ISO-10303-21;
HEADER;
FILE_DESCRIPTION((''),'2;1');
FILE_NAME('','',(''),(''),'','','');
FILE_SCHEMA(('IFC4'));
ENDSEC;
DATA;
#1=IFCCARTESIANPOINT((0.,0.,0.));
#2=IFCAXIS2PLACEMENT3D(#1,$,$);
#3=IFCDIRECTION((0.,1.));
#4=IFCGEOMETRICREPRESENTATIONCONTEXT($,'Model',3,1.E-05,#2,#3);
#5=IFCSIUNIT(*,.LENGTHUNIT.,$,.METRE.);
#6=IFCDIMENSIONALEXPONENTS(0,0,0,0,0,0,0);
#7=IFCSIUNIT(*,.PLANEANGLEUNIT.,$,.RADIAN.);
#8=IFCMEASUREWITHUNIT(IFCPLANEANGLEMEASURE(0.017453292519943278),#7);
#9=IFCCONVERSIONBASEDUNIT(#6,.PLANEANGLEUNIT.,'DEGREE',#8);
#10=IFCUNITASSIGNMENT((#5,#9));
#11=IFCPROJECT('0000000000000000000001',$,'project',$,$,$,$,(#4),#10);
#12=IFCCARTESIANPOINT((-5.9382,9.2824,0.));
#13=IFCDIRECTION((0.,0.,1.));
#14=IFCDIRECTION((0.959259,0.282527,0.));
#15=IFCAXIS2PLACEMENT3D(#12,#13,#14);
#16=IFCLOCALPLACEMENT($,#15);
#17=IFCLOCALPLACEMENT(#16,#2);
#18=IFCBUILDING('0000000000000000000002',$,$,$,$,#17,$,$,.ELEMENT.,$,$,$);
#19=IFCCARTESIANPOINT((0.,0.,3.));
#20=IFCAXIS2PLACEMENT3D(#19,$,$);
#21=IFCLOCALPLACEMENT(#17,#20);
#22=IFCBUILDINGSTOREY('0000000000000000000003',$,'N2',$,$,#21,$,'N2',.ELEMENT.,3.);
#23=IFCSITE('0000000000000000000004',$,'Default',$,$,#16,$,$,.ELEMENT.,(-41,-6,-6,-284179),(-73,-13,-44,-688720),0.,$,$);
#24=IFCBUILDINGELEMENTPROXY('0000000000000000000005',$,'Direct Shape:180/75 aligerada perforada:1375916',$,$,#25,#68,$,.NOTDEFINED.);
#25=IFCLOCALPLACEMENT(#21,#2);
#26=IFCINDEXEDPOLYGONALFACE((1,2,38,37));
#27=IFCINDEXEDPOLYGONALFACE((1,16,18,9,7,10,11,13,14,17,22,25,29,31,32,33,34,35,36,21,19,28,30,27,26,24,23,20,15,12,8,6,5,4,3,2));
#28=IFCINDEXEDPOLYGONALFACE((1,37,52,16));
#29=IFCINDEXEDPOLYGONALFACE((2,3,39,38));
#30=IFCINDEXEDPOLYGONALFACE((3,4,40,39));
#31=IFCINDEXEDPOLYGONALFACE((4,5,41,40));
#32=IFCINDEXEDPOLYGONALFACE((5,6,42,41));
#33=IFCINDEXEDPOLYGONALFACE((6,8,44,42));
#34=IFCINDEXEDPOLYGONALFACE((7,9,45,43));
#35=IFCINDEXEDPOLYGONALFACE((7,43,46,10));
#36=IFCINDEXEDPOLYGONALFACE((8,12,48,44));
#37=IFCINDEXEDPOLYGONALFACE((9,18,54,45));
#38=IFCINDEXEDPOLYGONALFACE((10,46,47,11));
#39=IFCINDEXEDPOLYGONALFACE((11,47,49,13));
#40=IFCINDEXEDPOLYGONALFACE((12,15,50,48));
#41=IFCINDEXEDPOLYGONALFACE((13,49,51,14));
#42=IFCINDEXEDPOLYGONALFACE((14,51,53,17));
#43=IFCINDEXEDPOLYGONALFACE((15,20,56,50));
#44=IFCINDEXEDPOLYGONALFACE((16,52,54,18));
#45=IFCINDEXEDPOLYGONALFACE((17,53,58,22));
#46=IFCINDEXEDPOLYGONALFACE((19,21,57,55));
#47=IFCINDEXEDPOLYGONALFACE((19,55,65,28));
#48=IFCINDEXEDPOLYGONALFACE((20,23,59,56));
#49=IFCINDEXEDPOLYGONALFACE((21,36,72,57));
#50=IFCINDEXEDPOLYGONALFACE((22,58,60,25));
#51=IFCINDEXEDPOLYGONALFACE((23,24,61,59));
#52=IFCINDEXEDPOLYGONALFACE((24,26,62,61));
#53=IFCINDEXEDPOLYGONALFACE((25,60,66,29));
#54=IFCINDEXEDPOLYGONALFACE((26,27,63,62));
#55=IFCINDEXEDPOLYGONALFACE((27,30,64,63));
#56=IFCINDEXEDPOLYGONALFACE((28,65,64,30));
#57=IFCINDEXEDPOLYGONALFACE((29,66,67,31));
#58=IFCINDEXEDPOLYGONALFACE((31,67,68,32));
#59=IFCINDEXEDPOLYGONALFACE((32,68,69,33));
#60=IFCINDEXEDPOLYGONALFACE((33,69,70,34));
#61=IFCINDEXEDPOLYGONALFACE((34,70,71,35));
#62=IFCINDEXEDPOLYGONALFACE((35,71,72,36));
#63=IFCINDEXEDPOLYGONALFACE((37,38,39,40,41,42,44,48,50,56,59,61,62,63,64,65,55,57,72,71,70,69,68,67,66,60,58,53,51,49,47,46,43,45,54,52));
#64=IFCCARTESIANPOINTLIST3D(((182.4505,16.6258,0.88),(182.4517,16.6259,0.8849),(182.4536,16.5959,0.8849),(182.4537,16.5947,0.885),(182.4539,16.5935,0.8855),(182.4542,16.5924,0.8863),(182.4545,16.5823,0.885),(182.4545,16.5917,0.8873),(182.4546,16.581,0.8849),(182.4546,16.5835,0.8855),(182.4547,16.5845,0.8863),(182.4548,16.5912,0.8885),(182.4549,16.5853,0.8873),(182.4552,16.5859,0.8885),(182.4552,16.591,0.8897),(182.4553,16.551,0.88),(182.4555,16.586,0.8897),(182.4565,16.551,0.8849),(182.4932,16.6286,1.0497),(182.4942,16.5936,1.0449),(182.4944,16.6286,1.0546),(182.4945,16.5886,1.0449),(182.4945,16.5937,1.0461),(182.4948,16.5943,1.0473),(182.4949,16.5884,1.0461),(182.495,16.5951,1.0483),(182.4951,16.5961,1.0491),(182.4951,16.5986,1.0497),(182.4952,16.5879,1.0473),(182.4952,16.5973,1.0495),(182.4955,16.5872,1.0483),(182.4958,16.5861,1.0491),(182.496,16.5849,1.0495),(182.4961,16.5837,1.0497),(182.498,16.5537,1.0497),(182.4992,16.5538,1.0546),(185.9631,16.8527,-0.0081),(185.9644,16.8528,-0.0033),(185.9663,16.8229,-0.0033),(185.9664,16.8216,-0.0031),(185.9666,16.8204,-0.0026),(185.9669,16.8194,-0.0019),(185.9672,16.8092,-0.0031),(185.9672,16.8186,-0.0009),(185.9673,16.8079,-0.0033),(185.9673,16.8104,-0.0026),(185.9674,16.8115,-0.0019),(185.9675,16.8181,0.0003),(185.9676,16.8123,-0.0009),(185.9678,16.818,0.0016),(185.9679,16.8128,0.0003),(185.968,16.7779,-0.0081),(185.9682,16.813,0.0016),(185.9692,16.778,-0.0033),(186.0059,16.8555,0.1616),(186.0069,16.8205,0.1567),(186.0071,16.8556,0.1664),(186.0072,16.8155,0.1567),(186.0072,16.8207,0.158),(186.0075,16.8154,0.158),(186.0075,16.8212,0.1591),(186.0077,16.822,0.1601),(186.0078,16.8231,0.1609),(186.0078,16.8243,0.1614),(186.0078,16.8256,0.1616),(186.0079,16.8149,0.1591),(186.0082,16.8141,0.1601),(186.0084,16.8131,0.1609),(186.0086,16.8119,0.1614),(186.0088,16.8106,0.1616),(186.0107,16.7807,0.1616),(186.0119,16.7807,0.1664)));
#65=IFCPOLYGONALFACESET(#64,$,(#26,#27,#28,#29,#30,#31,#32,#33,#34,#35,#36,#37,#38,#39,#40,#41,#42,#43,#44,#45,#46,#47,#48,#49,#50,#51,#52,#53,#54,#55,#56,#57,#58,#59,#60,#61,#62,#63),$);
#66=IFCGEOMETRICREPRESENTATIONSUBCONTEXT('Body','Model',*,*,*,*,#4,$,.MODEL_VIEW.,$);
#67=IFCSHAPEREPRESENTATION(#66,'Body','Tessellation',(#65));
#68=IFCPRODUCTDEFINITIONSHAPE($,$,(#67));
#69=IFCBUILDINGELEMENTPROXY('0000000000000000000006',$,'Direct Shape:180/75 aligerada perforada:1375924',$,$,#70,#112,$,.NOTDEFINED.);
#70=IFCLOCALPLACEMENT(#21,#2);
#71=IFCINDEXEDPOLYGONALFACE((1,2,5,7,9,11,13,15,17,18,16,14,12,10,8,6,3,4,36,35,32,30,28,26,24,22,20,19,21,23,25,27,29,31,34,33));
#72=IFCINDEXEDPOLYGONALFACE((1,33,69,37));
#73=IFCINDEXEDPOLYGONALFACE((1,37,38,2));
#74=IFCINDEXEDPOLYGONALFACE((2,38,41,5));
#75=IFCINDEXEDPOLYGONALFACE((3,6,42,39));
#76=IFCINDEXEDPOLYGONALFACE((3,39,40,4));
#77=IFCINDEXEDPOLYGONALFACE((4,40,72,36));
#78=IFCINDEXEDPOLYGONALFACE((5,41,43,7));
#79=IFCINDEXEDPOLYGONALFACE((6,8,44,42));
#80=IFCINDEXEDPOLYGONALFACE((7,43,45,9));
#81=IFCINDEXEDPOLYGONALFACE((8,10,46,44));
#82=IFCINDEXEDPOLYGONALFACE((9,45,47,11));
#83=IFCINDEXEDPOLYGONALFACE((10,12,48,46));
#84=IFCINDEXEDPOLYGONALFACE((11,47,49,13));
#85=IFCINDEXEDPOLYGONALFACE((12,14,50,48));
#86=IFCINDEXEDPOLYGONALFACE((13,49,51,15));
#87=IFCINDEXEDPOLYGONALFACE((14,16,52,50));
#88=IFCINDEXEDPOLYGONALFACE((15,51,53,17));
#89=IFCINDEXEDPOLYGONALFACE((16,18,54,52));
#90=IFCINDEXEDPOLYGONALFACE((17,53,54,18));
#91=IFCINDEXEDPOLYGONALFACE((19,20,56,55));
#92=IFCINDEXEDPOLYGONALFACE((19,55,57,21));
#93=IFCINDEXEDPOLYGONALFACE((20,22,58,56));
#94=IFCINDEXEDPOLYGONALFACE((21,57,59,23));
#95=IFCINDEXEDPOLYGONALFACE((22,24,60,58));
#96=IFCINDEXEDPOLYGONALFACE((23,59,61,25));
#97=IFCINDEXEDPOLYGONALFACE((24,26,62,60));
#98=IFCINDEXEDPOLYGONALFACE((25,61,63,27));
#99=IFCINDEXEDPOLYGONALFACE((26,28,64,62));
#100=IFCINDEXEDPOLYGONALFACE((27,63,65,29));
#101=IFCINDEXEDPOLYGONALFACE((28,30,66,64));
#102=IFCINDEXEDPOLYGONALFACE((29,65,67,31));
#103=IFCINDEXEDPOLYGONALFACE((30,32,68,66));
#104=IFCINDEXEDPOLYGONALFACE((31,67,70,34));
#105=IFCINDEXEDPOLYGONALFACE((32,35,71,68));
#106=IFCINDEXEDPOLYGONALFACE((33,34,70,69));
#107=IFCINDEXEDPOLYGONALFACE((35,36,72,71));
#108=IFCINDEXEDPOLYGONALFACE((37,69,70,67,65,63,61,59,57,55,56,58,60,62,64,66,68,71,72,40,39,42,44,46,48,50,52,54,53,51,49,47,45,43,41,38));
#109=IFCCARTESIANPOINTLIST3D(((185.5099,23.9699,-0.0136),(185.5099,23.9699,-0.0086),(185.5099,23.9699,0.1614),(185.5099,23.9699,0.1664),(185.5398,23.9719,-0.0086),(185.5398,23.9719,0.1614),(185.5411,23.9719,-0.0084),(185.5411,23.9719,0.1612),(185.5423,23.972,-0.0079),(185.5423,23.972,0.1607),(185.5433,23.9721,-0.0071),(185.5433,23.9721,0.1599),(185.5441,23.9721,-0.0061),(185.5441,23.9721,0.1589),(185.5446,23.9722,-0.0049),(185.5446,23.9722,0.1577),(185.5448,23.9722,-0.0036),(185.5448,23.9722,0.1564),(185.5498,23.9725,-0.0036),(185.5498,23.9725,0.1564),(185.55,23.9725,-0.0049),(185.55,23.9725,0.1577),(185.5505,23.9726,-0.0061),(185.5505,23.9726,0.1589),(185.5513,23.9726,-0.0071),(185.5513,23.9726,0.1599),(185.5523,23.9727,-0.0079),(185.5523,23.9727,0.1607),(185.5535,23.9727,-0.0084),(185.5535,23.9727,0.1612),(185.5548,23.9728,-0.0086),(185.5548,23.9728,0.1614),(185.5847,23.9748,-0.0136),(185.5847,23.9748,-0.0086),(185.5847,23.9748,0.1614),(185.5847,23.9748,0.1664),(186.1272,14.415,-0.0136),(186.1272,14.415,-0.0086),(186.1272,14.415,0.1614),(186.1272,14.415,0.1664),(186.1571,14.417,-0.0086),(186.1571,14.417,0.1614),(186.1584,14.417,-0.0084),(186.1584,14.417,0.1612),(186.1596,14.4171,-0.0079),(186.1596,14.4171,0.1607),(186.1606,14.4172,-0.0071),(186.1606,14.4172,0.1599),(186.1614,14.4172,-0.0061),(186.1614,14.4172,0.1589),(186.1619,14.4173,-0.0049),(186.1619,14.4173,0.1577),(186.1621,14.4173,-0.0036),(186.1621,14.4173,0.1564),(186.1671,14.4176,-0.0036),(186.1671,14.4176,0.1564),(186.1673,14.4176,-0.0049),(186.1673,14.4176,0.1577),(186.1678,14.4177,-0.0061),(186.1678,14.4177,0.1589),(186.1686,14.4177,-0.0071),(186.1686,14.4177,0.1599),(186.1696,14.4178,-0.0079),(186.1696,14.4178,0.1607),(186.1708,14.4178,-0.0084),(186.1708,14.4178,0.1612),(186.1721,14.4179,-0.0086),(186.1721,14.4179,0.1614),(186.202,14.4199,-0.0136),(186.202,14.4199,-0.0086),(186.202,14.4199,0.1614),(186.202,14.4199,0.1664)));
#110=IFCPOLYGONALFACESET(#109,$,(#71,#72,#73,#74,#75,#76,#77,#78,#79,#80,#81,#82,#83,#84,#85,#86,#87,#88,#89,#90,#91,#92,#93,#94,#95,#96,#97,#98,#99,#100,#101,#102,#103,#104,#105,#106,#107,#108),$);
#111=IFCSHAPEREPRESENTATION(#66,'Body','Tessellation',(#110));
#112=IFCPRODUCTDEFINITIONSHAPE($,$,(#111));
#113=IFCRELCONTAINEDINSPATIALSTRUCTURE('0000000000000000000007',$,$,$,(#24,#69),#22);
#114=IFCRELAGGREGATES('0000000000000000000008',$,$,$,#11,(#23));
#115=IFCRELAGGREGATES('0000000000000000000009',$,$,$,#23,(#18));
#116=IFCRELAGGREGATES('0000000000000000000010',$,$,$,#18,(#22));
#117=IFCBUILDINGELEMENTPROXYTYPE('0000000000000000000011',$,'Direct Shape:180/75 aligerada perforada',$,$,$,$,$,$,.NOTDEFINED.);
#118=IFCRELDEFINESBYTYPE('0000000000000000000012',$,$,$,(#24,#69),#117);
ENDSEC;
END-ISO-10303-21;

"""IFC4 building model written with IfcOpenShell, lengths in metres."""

from ifc_helpers import new_model, entity, si_unit, converted_unit, direction, frame, frame_2d, origin, place, context, subcontext, project, spatial, polyline, circle_curve, parameter, trimmed, segment, composite_curve, outline, extrude, type_object, element, save


model = new_model("IFC4")

# Units and contexts
model_context = context("Model", 3, precision=1e-05, world=origin(), true_north=direction((0.0, 1.0)))
body_context = subcontext(model_context, "Body", "Model", "MODEL_VIEW")
ifc_project = project(units=[si_unit("LENGTHUNIT", "METRE"), converted_unit("PLANEANGLEUNIT", "DEGREE", entity("IfcPlaneAngleMeasure", 0.017453292519943278), si_unit("PLANEANGLEUNIT", "RADIAN"), dimensions=[0, 0, 0, 0, 0, 0, 0])], contexts=[model_context])

# Site, building, storey
site_placement = place(None, frame((-5.9382, 9.2824, 0.0), z_axis=(0.0, 0.0, 1.0), x_axis=(0.959259, 0.282527, 0.0)))
site = spatial("IfcSite", under=ifc_project, at=site_placement, Name="Default", CompositionType="ELEMENT", RefLatitude=(-41, -6, -6, -284179), RefLongitude=(-73, -13, -44, -688720), RefElevation=0.0)
building_placement = place(site_placement, origin())
building = spatial("IfcBuilding", under=site, at=building_placement, CompositionType="ELEMENT")
storey_placement = place(building_placement, frame((0.0, 0.0, 3.0)))
storey = spatial("IfcBuildingStorey", under=building, at=storey_placement, Name="N2", LongName="N2", CompositionType="ELEMENT", Elevation=3.0)

# Building element proxies
building_element_proxy_type_1 = type_object("IfcBuildingElementProxyType", Name="Direct Shape:180/75 aligerada perforada", PredefinedType="NOTDEFINED")
proxy_1_placement = place(storey_placement, origin())
element("IfcBuildingElementProxy", 1, at=proxy_1_placement, inside=storey, type_object=building_element_proxy_type_1, Name="Direct Shape:180/75 aligerada perforada:1375916", PredefinedType="NOTDEFINED", context=body_context, shape_type="SweptSolid", body=[
    extrude(outline(composite_curve([segment(polyline([(-0.0375, -0.085), (-0.0375, -0.09)]), True, "CONTINUOUS"), segment(polyline([(-0.0375, -0.09), (0.0375, -0.09)]), True, "CONTINUOUS"), segment(polyline([(0.0375, -0.09), (0.0375, -0.085)]), True, "CONTINUOUS"), segment(polyline([(0.0375, -0.085), (0.0075, -0.085)]), True, "CONTINUOUS"), segment(trimmed(circle_curve(frame_2d((0.0075, -0.08), x_axis=(1.0, 0.0)), 0.005), [parameter(180.0)], [parameter(270.0)], True, "PARAMETER"), False, "CONTINUOUS"), segment(polyline([(0.0025, -0.08), (0.0025, 0.08)]), True, "CONTINUOUS"), segment(trimmed(circle_curve(frame_2d((0.0075, 0.08), x_axis=(1.0, 0.0)), 0.005), [parameter(90.0)], [parameter(180.0)], True, "PARAMETER"), False, "CONTINUOUS"), segment(polyline([(0.0075, 0.085), (0.0375, 0.085)]), True, "CONTINUOUS"), segment(polyline([(0.0375, 0.085), (0.0375, 0.09)]), True, "CONTINUOUS"), segment(polyline([(0.0375, 0.09), (-0.0375, 0.09)]), True, "CONTINUOUS"), segment(polyline([(-0.0375, 0.09), (-0.0375, 0.085)]), True, "CONTINUOUS"), segment(polyline([(-0.0375, 0.085), (-0.0075, 0.085)]), True, "CONTINUOUS"), segment(trimmed(circle_curve(frame_2d((-0.0075, 0.08), x_axis=(1.0, 0.0)), 0.005), [parameter(360.0)], [parameter(90.0)], True, "PARAMETER"), False, "CONTINUOUS"), segment(polyline([(-0.0025, 0.08), (-0.0025, -0.08)]), True, "CONTINUOUS"), segment(trimmed(circle_curve(frame_2d((-0.0075, -0.08), x_axis=(1.0, 0.0)), 0.005), [parameter(270.0)], [parameter(0.0)], True, "PARAMETER"), False, "CONTINUOUS"), segment(polyline([(-0.0075, -0.085), (-0.0375, -0.085)]), True, "CONTINUOUS")], self_intersect=False)), frame((182.4749, 16.5898, 0.9673), z_axis=(-0.967595, -0.062512, 0.244649), x_axis=(0.064471, -0.99792, 0.0)), (0.0, 0.0, -1.0), 3.6303),
])
proxy_2_placement = place(storey_placement, origin())
element("IfcBuildingElementProxy", 2, at=proxy_2_placement, inside=storey, type_object=building_element_proxy_type_1, Name="Direct Shape:180/75 aligerada perforada:1375924", PredefinedType="NOTDEFINED", context=body_context, shape_type="SweptSolid", body=[
    extrude(outline(composite_curve([segment(polyline([(0.085, -0.0375), (0.09, -0.0375)]), True, "CONTINUOUS"), segment(polyline([(0.09, -0.0375), (0.09, 0.0375)]), True, "CONTINUOUS"), segment(polyline([(0.09, 0.0375), (0.085, 0.0375)]), True, "CONTINUOUS"), segment(polyline([(0.085, 0.0375), (0.085, 0.0075)]), True, "CONTINUOUS"), segment(trimmed(circle_curve(frame_2d((0.08, 0.0075), x_axis=(1.0, 0.0)), 0.005), [parameter(270.0)], [parameter(0.0)], True, "PARAMETER"), False, "CONTINUOUS"), segment(polyline([(0.08, 0.0025), (-0.08, 0.0025)]), True, "CONTINUOUS"), segment(trimmed(circle_curve(frame_2d((-0.08, 0.0075), x_axis=(0.0, -1.0)), 0.005), [parameter(270.0)], [parameter(360.0)], True, "PARAMETER"), False, "CONTINUOUS"), segment(polyline([(-0.085, 0.0075), (-0.085, 0.0375)]), True, "CONTINUOUS"), segment(polyline([(-0.085, 0.0375), (-0.09, 0.0375)]), True, "CONTINUOUS"), segment(polyline([(-0.09, 0.0375), (-0.09, -0.0375)]), True, "CONTINUOUS"), segment(polyline([(-0.09, -0.0375), (-0.085, -0.0375)]), True, "CONTINUOUS"), segment(polyline([(-0.085, -0.0375), (-0.085, -0.0075)]), True, "CONTINUOUS"), segment(trimmed(circle_curve(frame_2d((-0.08, -0.0075), x_axis=(-1.0, 0.0)), 0.005), [parameter(270.0)], [parameter(0.0)], True, "PARAMETER"), False, "CONTINUOUS"), segment(polyline([(-0.08, -0.0025), (0.08, -0.0025)]), True, "CONTINUOUS"), segment(trimmed(circle_curve(frame_2d((0.08, -0.0075), x_axis=(0.0, 1.0)), 0.005), [parameter(270.0)], [parameter(0.0)], True, "PARAMETER"), False, "CONTINUOUS"), segment(polyline([(0.085, -0.0075), (0.085, -0.0375)]), True, "CONTINUOUS")], self_intersect=False)), frame((186.1646, 14.4174, 0.0764), z_axis=(-0.064471, 0.99792, 0.0), x_axis=(0.0, 0.0, -1.0)), (0.0, 0.0, 1.0), 9.5748),
])

save(model, "model.ifc")
